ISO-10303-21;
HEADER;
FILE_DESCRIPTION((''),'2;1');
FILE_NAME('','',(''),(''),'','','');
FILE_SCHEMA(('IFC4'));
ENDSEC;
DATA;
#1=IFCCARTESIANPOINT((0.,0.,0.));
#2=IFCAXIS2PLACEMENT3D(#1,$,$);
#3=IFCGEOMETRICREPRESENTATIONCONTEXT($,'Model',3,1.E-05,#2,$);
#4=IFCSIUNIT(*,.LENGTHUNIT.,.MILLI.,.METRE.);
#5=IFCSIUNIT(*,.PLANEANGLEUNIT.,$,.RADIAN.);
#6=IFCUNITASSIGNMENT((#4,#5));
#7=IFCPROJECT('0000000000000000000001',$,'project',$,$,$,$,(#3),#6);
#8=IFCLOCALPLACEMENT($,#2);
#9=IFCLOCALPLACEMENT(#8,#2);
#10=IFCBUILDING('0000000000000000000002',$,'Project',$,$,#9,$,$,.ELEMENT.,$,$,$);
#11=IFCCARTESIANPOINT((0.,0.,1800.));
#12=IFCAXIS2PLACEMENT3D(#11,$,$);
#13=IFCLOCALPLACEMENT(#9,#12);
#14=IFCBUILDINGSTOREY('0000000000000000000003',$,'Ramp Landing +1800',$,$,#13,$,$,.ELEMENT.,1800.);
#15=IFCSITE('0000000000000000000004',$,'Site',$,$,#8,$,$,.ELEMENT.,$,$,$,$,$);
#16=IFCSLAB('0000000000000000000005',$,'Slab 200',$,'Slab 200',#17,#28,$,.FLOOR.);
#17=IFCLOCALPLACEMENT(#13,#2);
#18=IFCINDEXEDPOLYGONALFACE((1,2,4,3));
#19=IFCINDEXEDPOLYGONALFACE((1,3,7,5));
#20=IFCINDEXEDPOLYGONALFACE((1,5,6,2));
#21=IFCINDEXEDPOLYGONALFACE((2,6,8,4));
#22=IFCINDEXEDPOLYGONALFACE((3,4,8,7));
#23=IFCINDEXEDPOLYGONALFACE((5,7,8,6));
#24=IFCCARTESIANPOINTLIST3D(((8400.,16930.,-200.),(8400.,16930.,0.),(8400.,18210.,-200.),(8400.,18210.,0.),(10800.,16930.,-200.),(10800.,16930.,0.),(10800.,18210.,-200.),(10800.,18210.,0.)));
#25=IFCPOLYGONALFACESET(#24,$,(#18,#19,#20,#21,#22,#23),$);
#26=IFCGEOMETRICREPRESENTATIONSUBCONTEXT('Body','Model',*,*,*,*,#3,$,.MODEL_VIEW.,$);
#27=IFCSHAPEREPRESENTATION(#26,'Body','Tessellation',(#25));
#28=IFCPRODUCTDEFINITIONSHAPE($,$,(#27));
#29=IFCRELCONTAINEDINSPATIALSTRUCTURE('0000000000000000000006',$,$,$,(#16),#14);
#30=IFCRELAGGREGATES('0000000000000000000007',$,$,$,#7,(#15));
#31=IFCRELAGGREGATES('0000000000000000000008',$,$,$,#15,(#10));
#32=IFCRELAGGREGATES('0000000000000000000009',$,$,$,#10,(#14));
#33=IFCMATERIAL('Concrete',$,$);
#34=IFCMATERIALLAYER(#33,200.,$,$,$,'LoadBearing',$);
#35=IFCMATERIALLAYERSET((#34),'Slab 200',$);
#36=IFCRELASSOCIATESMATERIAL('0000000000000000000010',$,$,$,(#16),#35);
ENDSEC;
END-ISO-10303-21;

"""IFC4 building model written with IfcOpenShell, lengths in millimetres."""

from ifc_helpers import new_model, si_unit, frame, origin, place, context, subcontext, project, spatial, polyline, outline, extrude, material, layer, layer_set, layer_usage, element, save


model = new_model("IFC4")

# Units and contexts
model_context = context("Model", 3, precision=1e-05, world=origin())
body_context = subcontext(model_context, "Body", "Model", "MODEL_VIEW")
ifc_project = project(units=[si_unit("LENGTHUNIT", "METRE", prefix="MILLI"), si_unit("PLANEANGLEUNIT", "RADIAN")], contexts=[model_context])

# Site, building, storey
site_placement = place(None, origin())
site = spatial("IfcSite", under=ifc_project, at=site_placement, Name="Site", CompositionType="ELEMENT")
building_placement = place(site_placement, origin())
building = spatial("IfcBuilding", under=site, at=building_placement, Name="Project", CompositionType="ELEMENT")
storey_placement = place(building_placement, frame((0.0, 0.0, 1800.0)))
storey = spatial("IfcBuildingStorey", under=building, at=storey_placement, Name="Ramp Landing +1800", CompositionType="ELEMENT", Elevation=1800.0)

# Slab
ifc_material = material(Name="Concrete")
ifc_layer = layer(ifc_material, 200.0, Category="LoadBearing")
ifc_layer_set = layer_set([ifc_layer], Name="Slab 200")
ifc_layer_usage = layer_usage(ifc_layer_set, "AXIS3", "NEGATIVE", 0.0)
slab_placement = place(storey_placement, origin())
element("IfcSlab", 1, at=slab_placement, inside=storey, material=ifc_layer_usage, Name="Slab 200", ObjectType="Slab 200", PredefinedType="FLOOR", context=body_context, shape_type="SweptSolid", body=[
    extrude(outline(polyline([(8400.0, 16930.0), (10800.0, 16930.0), (10800.0, 18210.0), (8400.0, 18210.0), (8400.0, 16930.0)])), frame((0.0, 0.0, -200.0)), (0.0, 0.0, 1.0), 200.0),
])

save(model, "model.ifc")
